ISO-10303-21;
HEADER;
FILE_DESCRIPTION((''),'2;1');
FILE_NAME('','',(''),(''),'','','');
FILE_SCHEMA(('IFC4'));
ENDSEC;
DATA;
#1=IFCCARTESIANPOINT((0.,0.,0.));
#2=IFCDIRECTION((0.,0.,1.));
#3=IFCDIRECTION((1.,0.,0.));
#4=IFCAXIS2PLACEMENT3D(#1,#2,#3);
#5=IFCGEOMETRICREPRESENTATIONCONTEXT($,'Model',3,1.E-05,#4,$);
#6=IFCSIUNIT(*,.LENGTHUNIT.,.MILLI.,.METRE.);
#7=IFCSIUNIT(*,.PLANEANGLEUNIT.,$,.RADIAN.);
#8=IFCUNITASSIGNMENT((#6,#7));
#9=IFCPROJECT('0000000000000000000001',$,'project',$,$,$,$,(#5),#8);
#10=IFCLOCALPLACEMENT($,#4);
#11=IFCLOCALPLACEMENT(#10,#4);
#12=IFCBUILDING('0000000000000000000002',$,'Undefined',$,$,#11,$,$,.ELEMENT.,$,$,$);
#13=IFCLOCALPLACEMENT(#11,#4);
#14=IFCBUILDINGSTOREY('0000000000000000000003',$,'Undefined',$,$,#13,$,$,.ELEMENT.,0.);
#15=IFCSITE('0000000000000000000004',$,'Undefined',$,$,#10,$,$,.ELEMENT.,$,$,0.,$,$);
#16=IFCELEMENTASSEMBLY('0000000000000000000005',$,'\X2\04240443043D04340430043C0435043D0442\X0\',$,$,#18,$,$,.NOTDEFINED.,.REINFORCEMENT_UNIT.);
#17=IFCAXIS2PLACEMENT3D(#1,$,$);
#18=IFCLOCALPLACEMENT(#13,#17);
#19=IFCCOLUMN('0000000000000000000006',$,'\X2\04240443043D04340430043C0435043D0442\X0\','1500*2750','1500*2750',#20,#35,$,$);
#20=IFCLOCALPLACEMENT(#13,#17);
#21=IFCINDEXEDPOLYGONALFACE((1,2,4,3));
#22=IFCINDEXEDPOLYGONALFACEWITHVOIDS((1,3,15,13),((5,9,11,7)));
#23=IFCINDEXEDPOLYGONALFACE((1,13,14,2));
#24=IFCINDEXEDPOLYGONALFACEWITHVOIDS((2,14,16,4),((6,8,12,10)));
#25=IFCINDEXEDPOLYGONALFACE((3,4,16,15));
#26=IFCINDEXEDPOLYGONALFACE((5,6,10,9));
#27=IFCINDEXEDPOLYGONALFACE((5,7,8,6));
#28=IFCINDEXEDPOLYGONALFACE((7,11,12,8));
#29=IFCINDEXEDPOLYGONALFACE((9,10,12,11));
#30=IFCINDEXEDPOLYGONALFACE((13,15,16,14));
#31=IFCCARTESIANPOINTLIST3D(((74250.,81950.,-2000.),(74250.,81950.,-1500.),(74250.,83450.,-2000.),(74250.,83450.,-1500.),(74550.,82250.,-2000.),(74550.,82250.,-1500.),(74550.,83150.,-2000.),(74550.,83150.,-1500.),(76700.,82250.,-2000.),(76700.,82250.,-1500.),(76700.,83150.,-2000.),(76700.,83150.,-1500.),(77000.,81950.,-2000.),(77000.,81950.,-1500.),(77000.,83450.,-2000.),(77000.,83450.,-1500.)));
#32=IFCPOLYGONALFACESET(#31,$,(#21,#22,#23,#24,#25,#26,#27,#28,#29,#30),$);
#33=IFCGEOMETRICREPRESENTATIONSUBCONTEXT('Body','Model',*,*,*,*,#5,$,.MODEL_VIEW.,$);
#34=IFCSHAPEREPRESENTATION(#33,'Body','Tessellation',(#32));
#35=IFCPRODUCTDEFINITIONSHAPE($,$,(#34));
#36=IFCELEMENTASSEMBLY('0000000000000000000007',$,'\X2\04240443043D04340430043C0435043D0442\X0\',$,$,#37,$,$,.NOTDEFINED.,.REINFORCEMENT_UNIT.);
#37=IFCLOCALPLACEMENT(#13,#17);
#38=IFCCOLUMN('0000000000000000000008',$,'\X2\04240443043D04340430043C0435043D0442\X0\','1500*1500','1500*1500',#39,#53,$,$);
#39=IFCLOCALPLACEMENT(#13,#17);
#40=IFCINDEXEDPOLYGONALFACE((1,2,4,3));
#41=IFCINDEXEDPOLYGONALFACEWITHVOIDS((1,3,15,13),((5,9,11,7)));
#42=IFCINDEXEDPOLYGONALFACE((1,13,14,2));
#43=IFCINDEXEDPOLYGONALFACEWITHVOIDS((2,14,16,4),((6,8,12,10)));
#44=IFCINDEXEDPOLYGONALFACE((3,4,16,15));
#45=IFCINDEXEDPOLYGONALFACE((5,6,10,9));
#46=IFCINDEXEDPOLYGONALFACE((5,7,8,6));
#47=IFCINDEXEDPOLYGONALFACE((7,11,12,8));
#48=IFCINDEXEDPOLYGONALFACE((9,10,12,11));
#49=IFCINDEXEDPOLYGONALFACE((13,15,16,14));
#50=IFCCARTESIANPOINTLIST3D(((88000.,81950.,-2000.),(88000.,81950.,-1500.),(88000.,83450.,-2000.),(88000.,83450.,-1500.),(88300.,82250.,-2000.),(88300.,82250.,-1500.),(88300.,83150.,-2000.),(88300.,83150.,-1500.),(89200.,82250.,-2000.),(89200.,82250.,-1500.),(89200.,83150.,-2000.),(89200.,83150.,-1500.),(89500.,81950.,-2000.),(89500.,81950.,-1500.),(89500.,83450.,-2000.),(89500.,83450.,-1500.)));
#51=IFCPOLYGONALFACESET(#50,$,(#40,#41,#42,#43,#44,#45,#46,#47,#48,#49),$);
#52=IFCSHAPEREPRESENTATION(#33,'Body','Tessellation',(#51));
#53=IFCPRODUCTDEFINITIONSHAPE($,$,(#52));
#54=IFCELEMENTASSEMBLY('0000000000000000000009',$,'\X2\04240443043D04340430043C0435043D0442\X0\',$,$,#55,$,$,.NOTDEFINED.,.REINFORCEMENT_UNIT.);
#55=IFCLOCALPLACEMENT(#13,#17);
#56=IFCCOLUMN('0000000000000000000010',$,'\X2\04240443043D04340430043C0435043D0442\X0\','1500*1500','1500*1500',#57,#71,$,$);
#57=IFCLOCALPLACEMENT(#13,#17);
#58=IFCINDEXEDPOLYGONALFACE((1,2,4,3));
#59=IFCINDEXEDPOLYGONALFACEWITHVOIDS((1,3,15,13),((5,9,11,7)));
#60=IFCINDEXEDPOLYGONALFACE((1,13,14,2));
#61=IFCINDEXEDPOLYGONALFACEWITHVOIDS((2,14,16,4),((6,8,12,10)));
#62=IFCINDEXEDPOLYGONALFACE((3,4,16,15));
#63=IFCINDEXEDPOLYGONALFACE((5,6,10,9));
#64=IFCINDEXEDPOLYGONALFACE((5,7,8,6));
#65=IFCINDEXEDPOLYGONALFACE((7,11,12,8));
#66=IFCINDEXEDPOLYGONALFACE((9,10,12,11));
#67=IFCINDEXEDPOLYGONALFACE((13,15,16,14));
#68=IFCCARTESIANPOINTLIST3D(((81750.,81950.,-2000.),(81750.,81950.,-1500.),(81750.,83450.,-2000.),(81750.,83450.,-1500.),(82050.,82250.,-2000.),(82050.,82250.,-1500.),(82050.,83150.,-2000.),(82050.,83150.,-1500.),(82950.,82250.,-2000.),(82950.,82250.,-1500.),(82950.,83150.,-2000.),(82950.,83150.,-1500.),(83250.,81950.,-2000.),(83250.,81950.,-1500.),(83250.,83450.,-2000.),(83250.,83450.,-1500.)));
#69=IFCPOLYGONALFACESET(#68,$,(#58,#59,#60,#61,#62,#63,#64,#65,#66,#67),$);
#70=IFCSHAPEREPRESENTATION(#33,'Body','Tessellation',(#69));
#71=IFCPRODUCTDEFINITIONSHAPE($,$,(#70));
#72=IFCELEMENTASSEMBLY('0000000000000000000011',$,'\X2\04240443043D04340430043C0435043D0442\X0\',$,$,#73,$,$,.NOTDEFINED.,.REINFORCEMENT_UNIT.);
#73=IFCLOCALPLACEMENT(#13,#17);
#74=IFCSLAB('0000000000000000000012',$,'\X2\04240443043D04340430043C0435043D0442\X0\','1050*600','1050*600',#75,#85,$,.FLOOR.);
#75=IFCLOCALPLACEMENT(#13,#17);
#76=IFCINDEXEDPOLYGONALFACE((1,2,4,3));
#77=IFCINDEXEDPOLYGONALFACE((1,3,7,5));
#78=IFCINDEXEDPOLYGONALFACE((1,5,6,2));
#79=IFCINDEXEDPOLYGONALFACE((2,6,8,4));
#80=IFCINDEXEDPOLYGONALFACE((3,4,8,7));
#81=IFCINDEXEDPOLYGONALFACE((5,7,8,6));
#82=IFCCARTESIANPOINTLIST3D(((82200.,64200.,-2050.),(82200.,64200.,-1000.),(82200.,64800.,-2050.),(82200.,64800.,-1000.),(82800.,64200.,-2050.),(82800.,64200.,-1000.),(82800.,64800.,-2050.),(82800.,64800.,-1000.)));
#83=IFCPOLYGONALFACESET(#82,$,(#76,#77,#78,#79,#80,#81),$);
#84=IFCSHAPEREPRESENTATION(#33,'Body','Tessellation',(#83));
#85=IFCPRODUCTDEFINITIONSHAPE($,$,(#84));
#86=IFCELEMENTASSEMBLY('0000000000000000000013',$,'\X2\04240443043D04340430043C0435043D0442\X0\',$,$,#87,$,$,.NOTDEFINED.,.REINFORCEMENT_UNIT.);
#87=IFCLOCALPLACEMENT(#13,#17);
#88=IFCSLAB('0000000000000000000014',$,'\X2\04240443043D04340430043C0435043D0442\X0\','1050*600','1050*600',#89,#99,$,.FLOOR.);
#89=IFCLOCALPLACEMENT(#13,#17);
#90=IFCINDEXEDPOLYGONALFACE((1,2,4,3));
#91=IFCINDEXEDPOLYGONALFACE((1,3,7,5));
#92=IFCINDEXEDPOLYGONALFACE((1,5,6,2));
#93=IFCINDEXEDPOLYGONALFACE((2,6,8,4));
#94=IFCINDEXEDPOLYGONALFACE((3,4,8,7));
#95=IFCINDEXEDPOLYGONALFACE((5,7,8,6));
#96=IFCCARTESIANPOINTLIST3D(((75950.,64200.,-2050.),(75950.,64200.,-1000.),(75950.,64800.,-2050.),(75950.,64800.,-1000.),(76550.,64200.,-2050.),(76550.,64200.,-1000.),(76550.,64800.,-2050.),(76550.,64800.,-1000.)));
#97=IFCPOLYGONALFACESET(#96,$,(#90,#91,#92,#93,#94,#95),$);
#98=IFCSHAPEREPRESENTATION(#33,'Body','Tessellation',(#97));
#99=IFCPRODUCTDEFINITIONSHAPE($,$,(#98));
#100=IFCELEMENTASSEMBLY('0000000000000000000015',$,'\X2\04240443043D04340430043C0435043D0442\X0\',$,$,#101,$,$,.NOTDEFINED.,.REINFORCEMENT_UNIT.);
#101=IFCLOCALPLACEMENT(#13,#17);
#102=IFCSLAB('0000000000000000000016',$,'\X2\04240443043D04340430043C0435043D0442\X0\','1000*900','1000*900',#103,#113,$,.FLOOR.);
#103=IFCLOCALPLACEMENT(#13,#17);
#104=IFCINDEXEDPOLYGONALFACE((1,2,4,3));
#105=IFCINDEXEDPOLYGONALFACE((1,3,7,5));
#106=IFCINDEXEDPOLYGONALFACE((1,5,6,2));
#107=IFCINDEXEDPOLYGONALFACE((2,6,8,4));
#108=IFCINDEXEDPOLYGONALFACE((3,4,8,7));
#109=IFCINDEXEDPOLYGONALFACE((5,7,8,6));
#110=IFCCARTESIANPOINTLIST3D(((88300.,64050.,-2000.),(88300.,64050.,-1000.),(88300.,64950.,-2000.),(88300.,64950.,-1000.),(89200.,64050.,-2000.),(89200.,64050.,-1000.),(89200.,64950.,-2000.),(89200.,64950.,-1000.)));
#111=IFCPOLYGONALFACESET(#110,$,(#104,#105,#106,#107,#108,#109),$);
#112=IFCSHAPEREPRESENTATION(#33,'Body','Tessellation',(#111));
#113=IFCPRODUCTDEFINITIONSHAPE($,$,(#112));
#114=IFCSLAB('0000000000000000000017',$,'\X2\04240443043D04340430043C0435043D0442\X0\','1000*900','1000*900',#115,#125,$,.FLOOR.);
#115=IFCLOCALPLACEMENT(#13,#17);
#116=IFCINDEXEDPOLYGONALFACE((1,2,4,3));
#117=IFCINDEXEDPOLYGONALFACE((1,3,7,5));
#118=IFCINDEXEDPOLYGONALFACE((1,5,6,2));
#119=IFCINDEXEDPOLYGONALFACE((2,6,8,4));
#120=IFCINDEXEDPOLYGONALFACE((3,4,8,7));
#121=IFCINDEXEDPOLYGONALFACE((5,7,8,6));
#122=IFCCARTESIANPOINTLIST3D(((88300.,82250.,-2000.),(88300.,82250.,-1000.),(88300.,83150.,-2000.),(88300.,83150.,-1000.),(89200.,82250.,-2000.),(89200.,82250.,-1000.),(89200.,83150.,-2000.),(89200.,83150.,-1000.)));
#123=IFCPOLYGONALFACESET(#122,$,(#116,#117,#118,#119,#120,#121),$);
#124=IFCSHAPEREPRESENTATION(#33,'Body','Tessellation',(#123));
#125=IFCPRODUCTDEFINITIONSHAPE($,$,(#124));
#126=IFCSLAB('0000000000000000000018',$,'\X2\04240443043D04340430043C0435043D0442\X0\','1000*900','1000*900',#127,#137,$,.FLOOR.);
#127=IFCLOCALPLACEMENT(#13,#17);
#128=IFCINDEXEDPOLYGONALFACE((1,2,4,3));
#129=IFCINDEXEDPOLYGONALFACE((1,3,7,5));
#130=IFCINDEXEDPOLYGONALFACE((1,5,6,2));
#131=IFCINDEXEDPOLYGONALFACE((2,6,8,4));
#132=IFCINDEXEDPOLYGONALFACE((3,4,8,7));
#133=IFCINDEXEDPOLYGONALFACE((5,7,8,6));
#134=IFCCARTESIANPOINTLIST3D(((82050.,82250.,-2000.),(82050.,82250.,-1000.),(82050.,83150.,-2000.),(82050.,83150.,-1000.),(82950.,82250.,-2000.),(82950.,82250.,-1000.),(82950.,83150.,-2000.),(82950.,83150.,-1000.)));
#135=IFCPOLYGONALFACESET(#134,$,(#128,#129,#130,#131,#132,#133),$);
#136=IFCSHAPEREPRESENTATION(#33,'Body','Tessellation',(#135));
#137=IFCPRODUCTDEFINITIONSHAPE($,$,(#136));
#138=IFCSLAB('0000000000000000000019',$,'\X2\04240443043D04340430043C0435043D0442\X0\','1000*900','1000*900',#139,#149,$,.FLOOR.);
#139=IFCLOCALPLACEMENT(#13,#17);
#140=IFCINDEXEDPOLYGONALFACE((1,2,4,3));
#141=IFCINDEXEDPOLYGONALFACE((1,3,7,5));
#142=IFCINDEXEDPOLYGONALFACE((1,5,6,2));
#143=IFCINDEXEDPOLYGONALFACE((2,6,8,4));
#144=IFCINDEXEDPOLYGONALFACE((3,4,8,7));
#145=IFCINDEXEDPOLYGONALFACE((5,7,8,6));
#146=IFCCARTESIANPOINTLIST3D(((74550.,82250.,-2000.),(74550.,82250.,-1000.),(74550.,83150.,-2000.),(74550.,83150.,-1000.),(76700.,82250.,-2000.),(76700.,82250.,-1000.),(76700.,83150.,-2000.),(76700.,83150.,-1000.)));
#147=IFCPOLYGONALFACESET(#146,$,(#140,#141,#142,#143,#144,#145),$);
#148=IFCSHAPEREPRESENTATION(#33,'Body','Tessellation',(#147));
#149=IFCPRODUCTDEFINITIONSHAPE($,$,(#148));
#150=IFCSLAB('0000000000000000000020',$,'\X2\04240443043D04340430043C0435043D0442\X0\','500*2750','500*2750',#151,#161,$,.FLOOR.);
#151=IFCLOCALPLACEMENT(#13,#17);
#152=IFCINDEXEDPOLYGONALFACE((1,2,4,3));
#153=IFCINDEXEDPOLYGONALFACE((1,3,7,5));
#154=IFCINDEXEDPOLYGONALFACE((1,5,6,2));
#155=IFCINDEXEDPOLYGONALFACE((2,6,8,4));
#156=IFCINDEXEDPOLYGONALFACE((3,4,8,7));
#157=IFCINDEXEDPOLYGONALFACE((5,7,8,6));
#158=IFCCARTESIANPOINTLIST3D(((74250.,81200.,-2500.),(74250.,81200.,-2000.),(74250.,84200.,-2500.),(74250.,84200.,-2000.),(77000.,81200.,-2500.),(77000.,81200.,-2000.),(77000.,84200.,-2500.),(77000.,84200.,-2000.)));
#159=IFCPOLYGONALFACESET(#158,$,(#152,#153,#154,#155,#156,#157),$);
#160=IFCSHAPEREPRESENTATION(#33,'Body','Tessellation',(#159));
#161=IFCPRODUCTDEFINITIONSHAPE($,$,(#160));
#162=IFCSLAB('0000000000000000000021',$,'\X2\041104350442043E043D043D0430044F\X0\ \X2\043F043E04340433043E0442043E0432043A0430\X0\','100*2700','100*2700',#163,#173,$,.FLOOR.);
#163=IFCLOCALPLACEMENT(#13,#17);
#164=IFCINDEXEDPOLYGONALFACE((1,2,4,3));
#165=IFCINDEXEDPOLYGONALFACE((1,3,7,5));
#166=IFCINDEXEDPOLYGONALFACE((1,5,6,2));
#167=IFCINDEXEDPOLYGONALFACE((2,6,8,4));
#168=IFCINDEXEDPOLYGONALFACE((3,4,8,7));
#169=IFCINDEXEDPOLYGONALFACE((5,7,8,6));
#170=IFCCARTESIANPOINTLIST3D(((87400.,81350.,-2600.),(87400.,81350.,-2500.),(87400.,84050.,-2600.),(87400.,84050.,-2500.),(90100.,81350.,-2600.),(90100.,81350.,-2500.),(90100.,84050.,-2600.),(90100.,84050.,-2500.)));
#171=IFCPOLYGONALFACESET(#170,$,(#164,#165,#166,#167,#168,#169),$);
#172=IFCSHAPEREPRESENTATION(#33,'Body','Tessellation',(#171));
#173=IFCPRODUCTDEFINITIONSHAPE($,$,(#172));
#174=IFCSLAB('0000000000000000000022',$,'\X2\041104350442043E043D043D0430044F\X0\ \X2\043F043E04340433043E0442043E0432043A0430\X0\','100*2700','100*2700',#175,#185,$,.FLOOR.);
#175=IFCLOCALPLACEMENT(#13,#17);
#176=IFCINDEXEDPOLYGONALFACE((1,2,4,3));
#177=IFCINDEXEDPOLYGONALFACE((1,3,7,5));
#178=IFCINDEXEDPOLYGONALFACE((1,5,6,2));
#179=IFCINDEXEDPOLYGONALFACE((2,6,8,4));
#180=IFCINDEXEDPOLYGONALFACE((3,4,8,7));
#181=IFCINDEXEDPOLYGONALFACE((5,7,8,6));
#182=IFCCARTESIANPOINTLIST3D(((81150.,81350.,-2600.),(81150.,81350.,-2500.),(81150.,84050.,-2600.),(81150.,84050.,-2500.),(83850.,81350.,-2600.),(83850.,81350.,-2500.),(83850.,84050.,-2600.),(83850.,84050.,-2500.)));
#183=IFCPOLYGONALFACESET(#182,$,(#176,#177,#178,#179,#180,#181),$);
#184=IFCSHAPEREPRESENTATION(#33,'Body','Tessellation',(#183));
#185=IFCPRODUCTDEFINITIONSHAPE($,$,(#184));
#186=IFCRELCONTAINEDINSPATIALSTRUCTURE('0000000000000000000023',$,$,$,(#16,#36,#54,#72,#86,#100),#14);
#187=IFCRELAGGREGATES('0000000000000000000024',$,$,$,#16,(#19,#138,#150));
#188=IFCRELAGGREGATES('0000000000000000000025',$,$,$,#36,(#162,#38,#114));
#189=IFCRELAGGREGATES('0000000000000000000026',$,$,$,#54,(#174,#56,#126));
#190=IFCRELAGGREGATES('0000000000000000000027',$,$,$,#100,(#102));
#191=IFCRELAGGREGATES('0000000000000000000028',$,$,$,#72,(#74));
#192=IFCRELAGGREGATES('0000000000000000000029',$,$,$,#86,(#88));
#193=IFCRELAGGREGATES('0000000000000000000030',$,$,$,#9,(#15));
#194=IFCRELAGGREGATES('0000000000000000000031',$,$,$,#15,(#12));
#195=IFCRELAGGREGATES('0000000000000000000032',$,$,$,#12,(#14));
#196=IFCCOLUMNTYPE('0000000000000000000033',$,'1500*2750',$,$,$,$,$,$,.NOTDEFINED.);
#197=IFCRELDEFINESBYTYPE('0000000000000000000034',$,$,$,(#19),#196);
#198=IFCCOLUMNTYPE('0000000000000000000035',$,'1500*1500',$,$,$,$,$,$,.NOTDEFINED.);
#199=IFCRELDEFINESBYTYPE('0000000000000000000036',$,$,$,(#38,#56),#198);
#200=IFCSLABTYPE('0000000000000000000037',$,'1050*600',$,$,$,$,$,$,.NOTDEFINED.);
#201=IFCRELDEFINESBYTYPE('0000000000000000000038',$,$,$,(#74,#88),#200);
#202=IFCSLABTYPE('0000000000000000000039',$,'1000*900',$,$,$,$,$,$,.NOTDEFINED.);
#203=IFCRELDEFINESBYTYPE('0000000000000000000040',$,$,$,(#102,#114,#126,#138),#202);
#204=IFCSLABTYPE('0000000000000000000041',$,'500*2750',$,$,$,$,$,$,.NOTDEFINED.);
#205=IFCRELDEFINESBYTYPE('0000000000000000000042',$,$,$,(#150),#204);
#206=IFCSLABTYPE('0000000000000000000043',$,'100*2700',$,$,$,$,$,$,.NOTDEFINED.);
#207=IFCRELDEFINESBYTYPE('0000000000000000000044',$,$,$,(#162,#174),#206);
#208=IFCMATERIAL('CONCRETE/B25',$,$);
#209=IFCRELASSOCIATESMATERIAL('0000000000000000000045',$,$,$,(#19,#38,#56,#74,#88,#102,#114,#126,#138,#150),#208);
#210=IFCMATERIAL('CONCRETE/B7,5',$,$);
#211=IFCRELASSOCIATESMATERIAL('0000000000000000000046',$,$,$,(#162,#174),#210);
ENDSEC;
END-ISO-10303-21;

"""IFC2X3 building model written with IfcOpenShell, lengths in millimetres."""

from ifc_helpers import new_model, si_unit, frame, origin_with_axes, origin_2d_with_axis, place, context, subcontext, project, spatial, polyline, rectangle, outline, extrude, boolean, material, type_object, element, aggregate, save


model = new_model("IFC2X3")

# Units and contexts
model_context = context("Model", 3, precision=1e-05, world=origin_with_axes())
body_context = subcontext(model_context, "Body", "Model", "MODEL_VIEW")
ifc_project = project(units=[si_unit("LENGTHUNIT", "METRE", prefix="MILLI"), si_unit("PLANEANGLEUNIT", "RADIAN")], contexts=[model_context])

# Site, building, storey
site_placement = place(None, origin_with_axes())
site = spatial("IfcSite", under=ifc_project, at=site_placement, Name="Undefined", CompositionType="ELEMENT", RefElevation=0.0)
building_placement = place(site_placement, origin_with_axes())
building = spatial("IfcBuilding", under=site, at=building_placement, Name="Undefined", CompositionType="ELEMENT")
storey_placement = place(building_placement, origin_with_axes())
storey = spatial("IfcBuildingStorey", under=building, at=storey_placement, Name="Undefined", CompositionType="ELEMENT", Elevation=0.0)

# Element assemblies, columns
assembly_1_placement = place(storey_placement, origin_with_axes())
assembly_1 = element("IfcElementAssembly", 1, at=assembly_1_placement, inside=storey, Name="Фундамент", AssemblyPlace="NOTDEFINED", PredefinedType="REINFORCEMENT_UNIT")
ifc_material_1 = material(Name="CONCRETE/B25")
column_type_1 = type_object("IfcColumnType", Name="1500*2750", PredefinedType="NOTDEFINED")
column_1_placement = place(assembly_1_placement, frame((75625.0, 82700.0, -2000.0), z_axis=(0.0, 0.0, 1.0), x_axis=(0.0, -1.0, 0.0)))
column_1 = element("IfcColumn", 2, at=column_1_placement, type_object=column_type_1, material=ifc_material_1, Name="Фундамент", Description="1500*2750", ObjectType="1500*2750", context=body_context, shape_type="CSG", body=[
    boolean("DIFFERENCE", extrude(rectangle(XDim=2750.0, YDim=1500.0, at=origin_2d_with_axis()), frame((0.0, 0.0, 500.0), z_axis=(0.0, 0.0, -1.0), x_axis=(0.0, 1.0, 0.0)), (0.0, 0.0, 1.0), 500.0), extrude(outline(polyline([(0.0, 0.0), (900.0, 0.0), (900.0, 2150.0), (0.0, 2150.0), (0.0, 0.0)])), frame((-450.0, -1075.0, -100.0), z_axis=(0.0, 0.0, 1.0), x_axis=(1.0, 0.0, 0.0)), (0.0, 0.0, 1.0), 700.0)),
])
assembly_2_placement = place(storey_placement, origin_with_axes())
assembly_2 = element("IfcElementAssembly", 3, at=assembly_2_placement, inside=storey, Name="Фундамент", AssemblyPlace="NOTDEFINED", PredefinedType="REINFORCEMENT_UNIT")
column_type_2 = type_object("IfcColumnType", Name="1500*1500", PredefinedType="NOTDEFINED")
column_2_placement = place(assembly_2_placement, frame((88750.0, 82700.0, -2000.0), z_axis=(0.0, 0.0, 1.0), x_axis=(0.0, -1.0, 0.0)))
column_2 = element("IfcColumn", 4, at=column_2_placement, type_object=column_type_2, material=ifc_material_1, Name="Фундамент", Description="1500*1500", ObjectType="1500*1500", context=body_context, shape_type="CSG", body=[
    boolean("DIFFERENCE", extrude(rectangle(XDim=1500.0, YDim=1500.0, at=origin_2d_with_axis()), frame((0.0, 0.0, 500.0), z_axis=(0.0, 0.0, -1.0), x_axis=(0.0, 1.0, 0.0)), (0.0, 0.0, 1.0), 500.0), extrude(outline(polyline([(0.0, 0.0), (900.0, 0.0), (900.0, 900.0), (0.0, 900.0), (0.0, 0.0)])), frame((-450.0, -450.0, -100.0), z_axis=(0.0, 0.0, 1.0), x_axis=(1.0, 0.0, 0.0)), (0.0, 0.0, 1.0), 700.0)),
])
assembly_3_placement = place(storey_placement, origin_with_axes())
assembly_3 = element("IfcElementAssembly", 5, at=assembly_3_placement, inside=storey, Name="Фундамент", AssemblyPlace="NOTDEFINED", PredefinedType="REINFORCEMENT_UNIT")
column_3_placement = place(assembly_3_placement, frame((82500.0, 82700.0, -2000.0), z_axis=(0.0, 0.0, 1.0), x_axis=(0.0, -1.0, 0.0)))
column_3 = element("IfcColumn", 6, at=column_3_placement, type_object=column_type_2, material=ifc_material_1, Name="Фундамент", Description="1500*1500", ObjectType="1500*1500", context=body_context, shape_type="CSG", body=[
    boolean("DIFFERENCE", extrude(rectangle(XDim=1500.0, YDim=1500.0, at=origin_2d_with_axis()), frame((0.0, 0.0, 500.0), z_axis=(0.0, 0.0, -1.0), x_axis=(0.0, 1.0, 0.0)), (0.0, 0.0, 1.0), 500.0), extrude(outline(polyline([(0.0, 0.0), (900.0, 0.0), (900.0, 900.0), (0.0, 900.0), (0.0, 0.0)])), frame((-450.0, -450.0, -100.0), z_axis=(0.0, 0.0, 1.0), x_axis=(1.0, 0.0, 0.0)), (0.0, 0.0, 1.0), 700.0)),
])

# Element assemblies, slabs
assembly_4_placement = place(storey_placement, origin_with_axes())
assembly_4 = element("IfcElementAssembly", 7, at=assembly_4_placement, inside=storey, Name="Фундамент", AssemblyPlace="NOTDEFINED", PredefinedType="REINFORCEMENT_UNIT")
slab_type_1 = type_object("IfcSlabType", Name="1050*600", PredefinedType="NOTDEFINED")
slab_1_placement = place(assembly_4_placement, frame((82200.0, 64800.0, -1525.0), z_axis=(0.0, 0.0, 1.0), x_axis=(0.0, -1.0, 0.0)))
slab_1 = element("IfcSlab", 8, at=slab_1_placement, type_object=slab_type_1, material=ifc_material_1, Name="Фундамент", Description="1050*600", ObjectType="1050*600", PredefinedType="FLOOR", context=body_context, shape_type="SweptSolid", body=[
    extrude(outline(polyline([(0.0, 0.0), (600.0, 0.0), (600.0, 600.0), (0.0, 600.0), (0.0, 0.0)])), frame((0.0, 0.0, -525.0), z_axis=(0.0, 0.0, 1.0), x_axis=(1.0, 0.0, 0.0)), (0.0, 0.0, 1.0), 1050.0),
])
assembly_5_placement = place(storey_placement, origin_with_axes())
assembly_5 = element("IfcElementAssembly", 9, at=assembly_5_placement, inside=storey, Name="Фундамент", AssemblyPlace="NOTDEFINED", PredefinedType="REINFORCEMENT_UNIT")
slab_2_placement = place(assembly_5_placement, frame((75950.0, 64800.0, -1525.0), z_axis=(0.0, 0.0, 1.0), x_axis=(0.0, -1.0, 0.0)))
slab_2 = element("IfcSlab", 10, at=slab_2_placement, type_object=slab_type_1, material=ifc_material_1, Name="Фундамент", Description="1050*600", ObjectType="1050*600", PredefinedType="FLOOR", context=body_context, shape_type="SweptSolid", body=[
    extrude(outline(polyline([(0.0, 0.0), (600.0, 0.0), (600.0, 600.0), (0.0, 600.0), (0.0, 0.0)])), frame((0.0, 0.0, -525.0), z_axis=(0.0, 0.0, 1.0), x_axis=(1.0, 0.0, 0.0)), (0.0, 0.0, 1.0), 1050.0),
])
assembly_6_placement = place(storey_placement, origin_with_axes())
assembly_6 = element("IfcElementAssembly", 11, at=assembly_6_placement, inside=storey, Name="Фундамент", AssemblyPlace="NOTDEFINED", PredefinedType="REINFORCEMENT_UNIT")
slab_type_2 = type_object("IfcSlabType", Name="1000*900", PredefinedType="NOTDEFINED")
slab_3_placement = place(assembly_6_placement, frame((88300.0, 64950.0, -1500.0), z_axis=(0.0, 0.0, 1.0), x_axis=(0.0, -1.0, 0.0)))
slab_3 = element("IfcSlab", 12, at=slab_3_placement, type_object=slab_type_2, material=ifc_material_1, Name="Фундамент", Description="1000*900", ObjectType="1000*900", PredefinedType="FLOOR", context=body_context, shape_type="SweptSolid", body=[
    extrude(outline(polyline([(0.0, 0.0), (900.0, 0.0), (900.0, 900.0), (0.0, 900.0), (0.0, 0.0)])), frame((0.0, 0.0, -500.0), z_axis=(0.0, 0.0, 1.0), x_axis=(1.0, 0.0, 0.0)), (0.0, 0.0, 1.0), 1000.0),
])

# Slabs
slab_4_placement = place(assembly_2_placement, frame((88300.0, 83150.0, -1500.0), z_axis=(0.0, 0.0, 1.0), x_axis=(0.0, -1.0, 0.0)))
slab_4 = element("IfcSlab", 13, at=slab_4_placement, type_object=slab_type_2, material=ifc_material_1, Name="Фундамент", Description="1000*900", ObjectType="1000*900", PredefinedType="FLOOR", context=body_context, shape_type="SweptSolid", body=[
    extrude(outline(polyline([(0.0, 0.0), (900.0, 0.0), (900.0, 900.0), (0.0, 900.0), (0.0, 0.0)])), frame((0.0, 0.0, -500.0), z_axis=(0.0, 0.0, 1.0), x_axis=(1.0, 0.0, 0.0)), (0.0, 0.0, 1.0), 1000.0),
])
slab_5_placement = place(assembly_3_placement, frame((82050.0, 83150.0, -1500.0), z_axis=(0.0, 0.0, 1.0), x_axis=(0.0, -1.0, 0.0)))
slab_5 = element("IfcSlab", 14, at=slab_5_placement, type_object=slab_type_2, material=ifc_material_1, Name="Фундамент", Description="1000*900", ObjectType="1000*900", PredefinedType="FLOOR", context=body_context, shape_type="SweptSolid", body=[
    extrude(outline(polyline([(0.0, 0.0), (900.0, 0.0), (900.0, 900.0), (0.0, 900.0), (0.0, 0.0)])), frame((0.0, 0.0, -500.0), z_axis=(0.0, 0.0, 1.0), x_axis=(1.0, 0.0, 0.0)), (0.0, 0.0, 1.0), 1000.0),
])
slab_6_placement = place(assembly_1_placement, frame((74550.0, 83150.0, -1500.0), z_axis=(0.0, 0.0, 1.0), x_axis=(0.0, -1.0, 0.0)))
slab_6 = element("IfcSlab", 15, at=slab_6_placement, type_object=slab_type_2, material=ifc_material_1, Name="Фундамент", Description="1000*900", ObjectType="1000*900", PredefinedType="FLOOR", context=body_context, shape_type="SweptSolid", body=[
    extrude(outline(polyline([(0.0, 0.0), (900.0, 0.0), (900.0, 2150.0), (0.0, 2150.0), (0.0, 0.0)])), frame((0.0, 0.0, -500.0), z_axis=(0.0, 0.0, 1.0), x_axis=(1.0, 0.0, 0.0)), (0.0, 0.0, 1.0), 1000.0),
])
slab_type_3 = type_object("IfcSlabType", Name="500*2750", PredefinedType="NOTDEFINED")
slab_7_placement = place(assembly_1_placement, frame((74250.0, 84200.0, -2250.0), z_axis=(0.0, 0.0, 1.0), x_axis=(0.0, -1.0, 0.0)))
slab_7 = element("IfcSlab", 16, at=slab_7_placement, type_object=slab_type_3, material=ifc_material_1, Name="Фундамент", Description="500*2750", ObjectType="500*2750", PredefinedType="FLOOR", context=body_context, shape_type="SweptSolid", body=[
    extrude(outline(polyline([(0.0, 0.0), (3000.0, 0.0), (3000.0, 2750.0), (0.0, 2750.0), (0.0, 0.0)])), frame((0.0, 0.0, -250.0), z_axis=(0.0, 0.0, 1.0), x_axis=(1.0, 0.0, 0.0)), (0.0, 0.0, 1.0), 500.0),
])
aggregate(assembly_1, [column_1, slab_6, slab_7])
ifc_material_2 = material(Name="CONCRETE/B7,5")
slab_type_4 = type_object("IfcSlabType", Name="100*2700", PredefinedType="NOTDEFINED")
slab_8_placement = place(assembly_2_placement, frame((87400.0, 84050.0, -2550.0), z_axis=(0.0, 0.0, 1.0), x_axis=(0.0, -1.0, 0.0)))
slab_8 = element("IfcSlab", 17, at=slab_8_placement, type_object=slab_type_4, material=ifc_material_2, Name="Бетонная подготовка", Description="100*2700", ObjectType="100*2700", PredefinedType="FLOOR", context=body_context, shape_type="SweptSolid", body=[
    extrude(outline(polyline([(0.0, 0.0), (2700.0, 0.0), (2700.0, 2700.0), (0.0, 2700.0), (0.0, 0.0)])), frame((0.0, 0.0, -50.0), z_axis=(0.0, 0.0, 1.0), x_axis=(1.0, 0.0, 0.0)), (0.0, 0.0, 1.0), 100.0),
])
slab_9_placement = place(assembly_3_placement, frame((81150.0, 84050.0, -2550.0), z_axis=(0.0, 0.0, 1.0), x_axis=(0.0, -1.0, 0.0)))
slab_9 = element("IfcSlab", 18, at=slab_9_placement, type_object=slab_type_4, material=ifc_material_2, Name="Бетонная подготовка", Description="100*2700", ObjectType="100*2700", PredefinedType="FLOOR", context=body_context, shape_type="SweptSolid", body=[
    extrude(outline(polyline([(0.0, 0.0), (2700.0, 0.0), (2700.0, 2700.0), (0.0, 2700.0), (0.0, 0.0)])), frame((0.0, 0.0, -50.0), z_axis=(0.0, 0.0, 1.0), x_axis=(1.0, 0.0, 0.0)), (0.0, 0.0, 1.0), 100.0),
])
aggregate(assembly_2, [slab_8, column_2, slab_4])
aggregate(assembly_3, [slab_9, column_3, slab_5])

aggregate(assembly_6, [slab_3])
aggregate(assembly_4, [slab_1])
aggregate(assembly_5, [slab_2])

save(model, "model.ifc")
